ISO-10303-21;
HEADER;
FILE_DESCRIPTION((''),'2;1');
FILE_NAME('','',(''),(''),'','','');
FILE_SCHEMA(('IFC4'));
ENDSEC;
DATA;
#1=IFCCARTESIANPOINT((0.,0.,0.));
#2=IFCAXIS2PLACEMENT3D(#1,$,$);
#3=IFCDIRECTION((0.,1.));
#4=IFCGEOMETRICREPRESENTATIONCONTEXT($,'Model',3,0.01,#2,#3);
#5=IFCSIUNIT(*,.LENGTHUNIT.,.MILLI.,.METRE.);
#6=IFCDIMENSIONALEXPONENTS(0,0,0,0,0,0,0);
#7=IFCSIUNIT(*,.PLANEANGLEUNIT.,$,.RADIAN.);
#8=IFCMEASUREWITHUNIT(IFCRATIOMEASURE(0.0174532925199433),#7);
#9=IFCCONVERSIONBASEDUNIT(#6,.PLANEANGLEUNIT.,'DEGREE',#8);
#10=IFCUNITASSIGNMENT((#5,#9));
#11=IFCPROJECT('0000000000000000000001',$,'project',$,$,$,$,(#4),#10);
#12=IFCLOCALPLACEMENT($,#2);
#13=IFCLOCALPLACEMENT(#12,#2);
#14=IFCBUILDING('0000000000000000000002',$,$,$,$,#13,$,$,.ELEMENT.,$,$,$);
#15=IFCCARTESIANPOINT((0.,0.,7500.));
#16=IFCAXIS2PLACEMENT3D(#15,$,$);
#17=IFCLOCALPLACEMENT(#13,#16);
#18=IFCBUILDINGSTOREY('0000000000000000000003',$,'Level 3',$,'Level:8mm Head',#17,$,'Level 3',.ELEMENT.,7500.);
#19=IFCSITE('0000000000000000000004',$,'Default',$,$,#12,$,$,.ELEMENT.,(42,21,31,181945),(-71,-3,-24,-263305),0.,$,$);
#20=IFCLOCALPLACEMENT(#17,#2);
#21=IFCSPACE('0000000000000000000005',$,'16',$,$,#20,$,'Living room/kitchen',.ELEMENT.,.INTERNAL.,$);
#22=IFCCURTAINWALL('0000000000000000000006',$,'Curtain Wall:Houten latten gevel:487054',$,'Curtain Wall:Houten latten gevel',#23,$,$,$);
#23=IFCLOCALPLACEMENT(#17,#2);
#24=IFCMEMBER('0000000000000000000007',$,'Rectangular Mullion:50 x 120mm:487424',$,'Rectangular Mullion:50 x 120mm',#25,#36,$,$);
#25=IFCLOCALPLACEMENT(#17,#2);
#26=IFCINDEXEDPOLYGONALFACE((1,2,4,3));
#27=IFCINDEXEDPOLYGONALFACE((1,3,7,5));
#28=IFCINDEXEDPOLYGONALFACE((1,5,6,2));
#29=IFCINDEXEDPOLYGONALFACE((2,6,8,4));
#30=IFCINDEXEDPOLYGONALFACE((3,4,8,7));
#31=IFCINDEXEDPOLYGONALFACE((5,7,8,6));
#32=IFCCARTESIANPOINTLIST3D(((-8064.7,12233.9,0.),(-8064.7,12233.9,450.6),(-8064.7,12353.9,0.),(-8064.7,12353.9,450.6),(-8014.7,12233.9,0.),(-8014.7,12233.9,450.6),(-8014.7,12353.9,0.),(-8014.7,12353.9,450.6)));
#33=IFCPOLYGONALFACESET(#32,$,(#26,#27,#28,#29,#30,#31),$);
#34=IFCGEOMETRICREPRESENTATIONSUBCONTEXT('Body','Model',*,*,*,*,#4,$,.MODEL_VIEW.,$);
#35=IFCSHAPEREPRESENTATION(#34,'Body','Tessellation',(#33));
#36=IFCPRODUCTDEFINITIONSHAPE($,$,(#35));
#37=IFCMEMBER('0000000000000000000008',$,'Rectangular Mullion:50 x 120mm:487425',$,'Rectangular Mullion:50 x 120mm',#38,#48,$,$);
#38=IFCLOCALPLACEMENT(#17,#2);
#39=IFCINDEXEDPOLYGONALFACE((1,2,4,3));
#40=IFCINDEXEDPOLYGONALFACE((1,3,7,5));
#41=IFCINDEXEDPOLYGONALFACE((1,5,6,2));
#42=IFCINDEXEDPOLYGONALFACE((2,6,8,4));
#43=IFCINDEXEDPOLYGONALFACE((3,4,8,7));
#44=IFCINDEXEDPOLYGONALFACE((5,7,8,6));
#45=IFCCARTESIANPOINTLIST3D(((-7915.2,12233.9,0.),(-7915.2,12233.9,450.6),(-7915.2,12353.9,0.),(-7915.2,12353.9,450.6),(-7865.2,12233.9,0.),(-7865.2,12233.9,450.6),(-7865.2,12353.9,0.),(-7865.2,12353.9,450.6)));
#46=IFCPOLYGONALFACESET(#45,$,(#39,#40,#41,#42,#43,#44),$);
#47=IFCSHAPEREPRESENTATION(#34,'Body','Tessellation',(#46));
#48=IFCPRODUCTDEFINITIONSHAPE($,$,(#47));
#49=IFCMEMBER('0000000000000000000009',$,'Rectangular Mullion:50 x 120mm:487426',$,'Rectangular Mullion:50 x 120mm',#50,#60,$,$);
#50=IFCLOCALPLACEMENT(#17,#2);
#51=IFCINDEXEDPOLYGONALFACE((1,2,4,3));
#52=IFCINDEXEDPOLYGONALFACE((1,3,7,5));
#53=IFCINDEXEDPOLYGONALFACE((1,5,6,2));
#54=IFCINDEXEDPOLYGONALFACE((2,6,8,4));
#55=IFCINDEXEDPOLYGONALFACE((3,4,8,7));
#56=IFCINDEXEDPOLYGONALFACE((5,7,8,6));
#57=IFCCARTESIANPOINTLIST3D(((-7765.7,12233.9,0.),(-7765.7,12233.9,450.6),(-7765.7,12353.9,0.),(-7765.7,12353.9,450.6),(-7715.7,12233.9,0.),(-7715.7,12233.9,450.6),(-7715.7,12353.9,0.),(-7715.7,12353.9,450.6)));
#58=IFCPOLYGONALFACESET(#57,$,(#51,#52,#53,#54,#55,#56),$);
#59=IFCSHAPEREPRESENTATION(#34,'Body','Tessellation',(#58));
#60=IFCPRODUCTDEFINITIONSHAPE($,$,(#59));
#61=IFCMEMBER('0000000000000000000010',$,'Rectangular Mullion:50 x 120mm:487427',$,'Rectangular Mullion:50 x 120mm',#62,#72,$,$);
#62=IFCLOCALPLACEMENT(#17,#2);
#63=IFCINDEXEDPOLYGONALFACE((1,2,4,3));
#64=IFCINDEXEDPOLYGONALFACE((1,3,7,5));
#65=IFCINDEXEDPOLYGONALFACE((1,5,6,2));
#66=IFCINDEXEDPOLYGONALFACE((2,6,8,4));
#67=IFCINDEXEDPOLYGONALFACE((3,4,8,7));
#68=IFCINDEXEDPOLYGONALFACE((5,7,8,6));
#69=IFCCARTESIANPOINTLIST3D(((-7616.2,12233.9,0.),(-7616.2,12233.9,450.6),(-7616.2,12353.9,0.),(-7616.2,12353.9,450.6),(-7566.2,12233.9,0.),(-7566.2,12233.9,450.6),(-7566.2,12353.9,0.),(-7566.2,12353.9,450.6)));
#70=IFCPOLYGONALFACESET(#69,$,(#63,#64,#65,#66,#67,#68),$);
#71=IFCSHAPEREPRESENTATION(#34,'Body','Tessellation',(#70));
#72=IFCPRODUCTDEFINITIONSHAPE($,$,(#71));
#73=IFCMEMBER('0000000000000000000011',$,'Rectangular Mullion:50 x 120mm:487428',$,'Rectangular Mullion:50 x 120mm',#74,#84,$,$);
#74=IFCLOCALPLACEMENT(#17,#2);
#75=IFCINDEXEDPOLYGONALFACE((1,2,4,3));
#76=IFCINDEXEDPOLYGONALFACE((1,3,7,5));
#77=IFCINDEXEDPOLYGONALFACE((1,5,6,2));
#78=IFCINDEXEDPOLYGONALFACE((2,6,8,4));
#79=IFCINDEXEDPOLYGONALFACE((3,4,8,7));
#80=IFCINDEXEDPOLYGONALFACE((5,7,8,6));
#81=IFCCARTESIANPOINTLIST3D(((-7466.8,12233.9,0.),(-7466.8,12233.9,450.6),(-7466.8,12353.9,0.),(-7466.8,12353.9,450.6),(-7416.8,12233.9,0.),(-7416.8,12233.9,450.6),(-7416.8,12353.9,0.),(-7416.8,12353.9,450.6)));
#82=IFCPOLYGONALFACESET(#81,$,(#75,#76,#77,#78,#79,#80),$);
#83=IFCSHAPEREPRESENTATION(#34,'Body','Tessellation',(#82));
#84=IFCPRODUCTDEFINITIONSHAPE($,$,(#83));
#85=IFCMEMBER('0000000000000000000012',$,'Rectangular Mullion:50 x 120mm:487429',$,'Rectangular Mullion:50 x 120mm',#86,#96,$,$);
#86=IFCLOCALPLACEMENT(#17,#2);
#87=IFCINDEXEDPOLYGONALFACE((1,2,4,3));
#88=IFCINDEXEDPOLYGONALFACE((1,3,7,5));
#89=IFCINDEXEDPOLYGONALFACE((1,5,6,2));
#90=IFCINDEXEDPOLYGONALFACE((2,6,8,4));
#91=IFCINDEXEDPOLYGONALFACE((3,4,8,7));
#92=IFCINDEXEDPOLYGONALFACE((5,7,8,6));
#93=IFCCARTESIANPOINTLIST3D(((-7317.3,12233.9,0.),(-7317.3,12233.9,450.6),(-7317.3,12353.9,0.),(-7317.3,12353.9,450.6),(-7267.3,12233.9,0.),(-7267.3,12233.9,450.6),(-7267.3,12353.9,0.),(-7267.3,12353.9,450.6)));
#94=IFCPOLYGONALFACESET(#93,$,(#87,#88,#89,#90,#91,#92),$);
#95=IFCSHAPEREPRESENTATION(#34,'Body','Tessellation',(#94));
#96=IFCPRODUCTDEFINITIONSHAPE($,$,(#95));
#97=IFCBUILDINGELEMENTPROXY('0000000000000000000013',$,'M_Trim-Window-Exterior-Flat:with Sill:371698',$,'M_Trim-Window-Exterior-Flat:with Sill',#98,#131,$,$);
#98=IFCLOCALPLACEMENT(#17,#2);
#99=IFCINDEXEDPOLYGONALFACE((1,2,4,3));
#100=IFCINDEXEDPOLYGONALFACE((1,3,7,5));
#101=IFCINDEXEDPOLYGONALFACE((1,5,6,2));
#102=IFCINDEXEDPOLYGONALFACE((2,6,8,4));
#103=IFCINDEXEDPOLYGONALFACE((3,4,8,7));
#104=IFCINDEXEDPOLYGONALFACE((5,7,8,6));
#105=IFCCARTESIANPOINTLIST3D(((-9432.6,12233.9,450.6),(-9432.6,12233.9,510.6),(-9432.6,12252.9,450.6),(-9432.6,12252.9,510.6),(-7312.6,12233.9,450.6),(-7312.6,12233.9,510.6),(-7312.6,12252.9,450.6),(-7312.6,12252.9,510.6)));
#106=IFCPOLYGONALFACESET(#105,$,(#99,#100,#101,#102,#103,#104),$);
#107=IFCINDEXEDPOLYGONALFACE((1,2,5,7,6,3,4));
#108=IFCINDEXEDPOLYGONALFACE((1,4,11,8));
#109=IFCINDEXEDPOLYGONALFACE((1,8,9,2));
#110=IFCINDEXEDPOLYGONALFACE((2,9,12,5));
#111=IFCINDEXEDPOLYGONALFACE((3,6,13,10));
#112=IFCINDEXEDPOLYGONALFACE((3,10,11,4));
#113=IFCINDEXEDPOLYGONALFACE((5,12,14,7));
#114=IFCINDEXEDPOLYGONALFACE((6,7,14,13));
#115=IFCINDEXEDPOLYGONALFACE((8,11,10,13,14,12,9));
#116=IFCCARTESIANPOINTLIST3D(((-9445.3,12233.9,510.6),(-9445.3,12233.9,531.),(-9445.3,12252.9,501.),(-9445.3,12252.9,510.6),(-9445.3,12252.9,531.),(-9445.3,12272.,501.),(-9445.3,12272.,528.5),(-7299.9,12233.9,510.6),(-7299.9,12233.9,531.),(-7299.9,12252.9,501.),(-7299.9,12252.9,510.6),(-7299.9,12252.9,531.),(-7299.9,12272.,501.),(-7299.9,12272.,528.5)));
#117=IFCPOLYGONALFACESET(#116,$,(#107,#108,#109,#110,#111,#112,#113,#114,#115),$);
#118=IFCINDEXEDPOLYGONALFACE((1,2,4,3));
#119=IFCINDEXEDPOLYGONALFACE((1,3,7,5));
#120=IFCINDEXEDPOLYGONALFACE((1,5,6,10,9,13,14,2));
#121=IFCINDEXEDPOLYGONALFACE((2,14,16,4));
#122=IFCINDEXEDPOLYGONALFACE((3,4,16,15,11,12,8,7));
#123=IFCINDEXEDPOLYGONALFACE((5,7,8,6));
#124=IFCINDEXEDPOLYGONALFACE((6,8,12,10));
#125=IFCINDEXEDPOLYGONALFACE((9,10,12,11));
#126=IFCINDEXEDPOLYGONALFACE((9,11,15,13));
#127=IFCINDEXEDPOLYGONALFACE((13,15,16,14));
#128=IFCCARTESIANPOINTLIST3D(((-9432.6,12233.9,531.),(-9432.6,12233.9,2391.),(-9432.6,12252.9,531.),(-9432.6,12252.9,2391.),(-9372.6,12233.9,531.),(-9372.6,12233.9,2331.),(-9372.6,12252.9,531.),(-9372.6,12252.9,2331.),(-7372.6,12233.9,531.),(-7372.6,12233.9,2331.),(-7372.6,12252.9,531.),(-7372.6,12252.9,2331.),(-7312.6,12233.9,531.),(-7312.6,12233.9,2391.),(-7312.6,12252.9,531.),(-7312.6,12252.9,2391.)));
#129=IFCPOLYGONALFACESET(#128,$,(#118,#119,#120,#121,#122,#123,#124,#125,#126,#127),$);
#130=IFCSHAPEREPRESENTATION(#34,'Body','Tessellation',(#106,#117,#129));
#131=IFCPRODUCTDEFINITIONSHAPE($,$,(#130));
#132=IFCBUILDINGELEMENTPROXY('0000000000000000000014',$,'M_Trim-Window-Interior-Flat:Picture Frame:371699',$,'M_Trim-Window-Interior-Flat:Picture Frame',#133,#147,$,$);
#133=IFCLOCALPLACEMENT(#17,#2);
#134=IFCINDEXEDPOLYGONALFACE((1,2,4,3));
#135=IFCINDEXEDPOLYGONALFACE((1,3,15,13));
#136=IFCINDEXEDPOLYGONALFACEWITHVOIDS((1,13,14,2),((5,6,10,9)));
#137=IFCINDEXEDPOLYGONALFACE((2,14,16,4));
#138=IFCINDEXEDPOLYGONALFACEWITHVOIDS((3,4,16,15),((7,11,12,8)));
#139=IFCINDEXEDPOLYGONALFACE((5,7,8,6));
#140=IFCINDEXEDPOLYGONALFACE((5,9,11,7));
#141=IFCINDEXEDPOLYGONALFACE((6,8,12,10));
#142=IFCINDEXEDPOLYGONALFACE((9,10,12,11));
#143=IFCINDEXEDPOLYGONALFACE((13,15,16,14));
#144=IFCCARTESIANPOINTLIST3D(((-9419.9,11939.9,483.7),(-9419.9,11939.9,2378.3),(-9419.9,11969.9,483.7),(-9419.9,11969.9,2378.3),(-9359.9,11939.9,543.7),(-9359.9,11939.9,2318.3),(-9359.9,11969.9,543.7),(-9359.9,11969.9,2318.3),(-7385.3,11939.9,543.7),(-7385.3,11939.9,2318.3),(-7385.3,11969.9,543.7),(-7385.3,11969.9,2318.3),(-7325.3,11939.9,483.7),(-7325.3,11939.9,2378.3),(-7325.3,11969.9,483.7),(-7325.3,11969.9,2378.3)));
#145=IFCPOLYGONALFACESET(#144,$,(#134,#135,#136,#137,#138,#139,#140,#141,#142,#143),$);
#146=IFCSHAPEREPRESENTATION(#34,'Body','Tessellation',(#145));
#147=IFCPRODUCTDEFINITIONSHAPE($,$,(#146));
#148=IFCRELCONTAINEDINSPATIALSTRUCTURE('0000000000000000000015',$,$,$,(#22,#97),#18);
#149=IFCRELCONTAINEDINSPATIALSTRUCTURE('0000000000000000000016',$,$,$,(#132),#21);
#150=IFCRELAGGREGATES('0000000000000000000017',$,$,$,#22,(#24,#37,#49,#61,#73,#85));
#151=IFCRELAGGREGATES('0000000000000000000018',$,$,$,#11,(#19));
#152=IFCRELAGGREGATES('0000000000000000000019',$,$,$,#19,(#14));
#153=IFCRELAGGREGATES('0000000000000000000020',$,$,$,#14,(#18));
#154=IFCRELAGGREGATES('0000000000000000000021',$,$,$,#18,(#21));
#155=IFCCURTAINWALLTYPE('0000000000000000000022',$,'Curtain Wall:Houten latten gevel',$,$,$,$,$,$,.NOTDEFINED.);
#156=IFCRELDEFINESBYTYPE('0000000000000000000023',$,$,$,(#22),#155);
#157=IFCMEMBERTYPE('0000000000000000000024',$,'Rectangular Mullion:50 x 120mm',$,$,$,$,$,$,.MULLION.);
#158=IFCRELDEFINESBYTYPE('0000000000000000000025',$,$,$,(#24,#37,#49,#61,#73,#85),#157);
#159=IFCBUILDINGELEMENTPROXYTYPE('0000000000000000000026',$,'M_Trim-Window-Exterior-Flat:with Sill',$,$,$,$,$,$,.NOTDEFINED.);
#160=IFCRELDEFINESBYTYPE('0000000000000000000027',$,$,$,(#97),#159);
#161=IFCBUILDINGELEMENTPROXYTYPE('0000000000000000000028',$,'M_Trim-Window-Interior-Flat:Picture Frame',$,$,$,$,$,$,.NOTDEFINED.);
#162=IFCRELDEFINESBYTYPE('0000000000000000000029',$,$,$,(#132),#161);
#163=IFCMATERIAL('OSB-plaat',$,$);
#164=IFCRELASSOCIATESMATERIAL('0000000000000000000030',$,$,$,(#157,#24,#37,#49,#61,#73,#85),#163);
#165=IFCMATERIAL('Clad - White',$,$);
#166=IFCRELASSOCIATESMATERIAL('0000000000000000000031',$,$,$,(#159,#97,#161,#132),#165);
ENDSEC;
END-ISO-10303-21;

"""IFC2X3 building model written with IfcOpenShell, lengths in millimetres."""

from ifc_helpers import new_model, entity, si_unit, converted_unit, direction, frame, frame_2d, origin, origin_2d_with_axis, place, context, subcontext, project, spatial, polyline, rectangle, outline, extrude, source, transform, mapped, material, type_object, type_shapes, element, aggregate, save


model = new_model("IFC2X3")

# Units and contexts
model_context = context("Model", 3, precision=0.01, world=origin(), true_north=direction((0.0, 1.0)))
body_context = subcontext(model_context, "Body", "Model", "MODEL_VIEW")
ifc_project = project(units=[si_unit("LENGTHUNIT", "METRE", prefix="MILLI"), converted_unit("PLANEANGLEUNIT", "DEGREE", entity("IfcRatioMeasure", 0.0174532925199433), si_unit("PLANEANGLEUNIT", "RADIAN"), dimensions=[0, 0, 0, 0, 0, 0, 0])], contexts=[model_context])

# Site, building, storey
site_placement = place(None, frame((0.0, 0.0, 0.0)))
site = spatial("IfcSite", under=ifc_project, at=site_placement, Name="Default", CompositionType="ELEMENT", RefLatitude=(42, 21, 31, 181945), RefLongitude=(-71, -3, -24, -263305), RefElevation=0.0)
building_placement = place(site_placement, origin())
building = spatial("IfcBuilding", under=site, at=building_placement, CompositionType="ELEMENT")
storey_placement = place(building_placement, frame((0.0, 0.0, 7500.0)))
storey = spatial("IfcBuildingStorey", under=building, at=storey_placement, Name="Level 3", ObjectType="Level:8mm Head", LongName="Level 3", CompositionType="ELEMENT", Elevation=7500.0)

# Curtain wall, members
curtain_wall_type = type_object("IfcCurtainWallType", Name="Curtain Wall:Houten latten gevel", PredefinedType="NOTDEFINED")
curtain_wall_placement = place(storey_placement, frame((0.0, 0.0, -7500.0)))
curtain_wall = element("IfcCurtainWall", 1, at=curtain_wall_placement, inside=storey, type_object=curtain_wall_type, Name="Curtain Wall:Houten latten gevel:487054", ObjectType="Curtain Wall:Houten latten gevel")
ifc_material_1 = material(Name="OSB-plaat")
member_type_1 = type_object("IfcMemberType", Name="Rectangular Mullion:50 x 120mm", PredefinedType="MULLION", material=ifc_material_1)
shared_shape_1 = source(origin(), body_context, "Body", "SweptSolid", [
    extrude(rectangle(XDim=120.0, YDim=50.0, at=origin_2d_with_axis()), frame((0.0, 0.0, -450.6), z_axis=(0.0, 0.0, 1.0), x_axis=(0.0, -1.0, 0.0)), (0.0, 0.0, 1.0), 450.6),
])
type_shapes(member_type_1, [shared_shape_1])
member_1_placement = place(storey_placement, frame((-8039.7, 12293.9, 0.0), z_axis=(0.0, 0.0, -1.0), x_axis=(1.0, 0.0, 0.0)))
member_1 = element("IfcMember", 2, at=member_1_placement, type_object=member_type_1, material=ifc_material_1, Name="Rectangular Mullion:50 x 120mm:487424", ObjectType="Rectangular Mullion:50 x 120mm", context=body_context, shape_type="MappedRepresentation", body=[
    mapped(shared_shape_1, transform((0.0, 0.0, 0.0), scale=1.0)),
])
member_2_placement = place(storey_placement, frame((-7890.2, 12293.9, 0.0), z_axis=(0.0, 0.0, -1.0), x_axis=(1.0, 0.0, 0.0)))
member_2 = element("IfcMember", 3, at=member_2_placement, type_object=member_type_1, material=ifc_material_1, Name="Rectangular Mullion:50 x 120mm:487425", ObjectType="Rectangular Mullion:50 x 120mm", context=body_context, shape_type="MappedRepresentation", body=[
    mapped(shared_shape_1, transform((0.0, 0.0, 0.0), scale=1.0)),
])
member_3_placement = place(storey_placement, frame((-7740.7, 12293.9, 0.0), z_axis=(0.0, 0.0, -1.0), x_axis=(1.0, 0.0, 0.0)))
member_3 = element("IfcMember", 4, at=member_3_placement, type_object=member_type_1, material=ifc_material_1, Name="Rectangular Mullion:50 x 120mm:487426", ObjectType="Rectangular Mullion:50 x 120mm", context=body_context, shape_type="MappedRepresentation", body=[
    mapped(shared_shape_1, transform((0.0, 0.0, 0.0), scale=1.0)),
])
member_4_placement = place(storey_placement, frame((-7591.2, 12293.9, 0.0), z_axis=(0.0, 0.0, -1.0), x_axis=(1.0, 0.0, 0.0)))
member_4 = element("IfcMember", 5, at=member_4_placement, type_object=member_type_1, material=ifc_material_1, Name="Rectangular Mullion:50 x 120mm:487427", ObjectType="Rectangular Mullion:50 x 120mm", context=body_context, shape_type="MappedRepresentation", body=[
    mapped(shared_shape_1, transform((0.0, 0.0, 0.0), scale=1.0)),
])
member_5_placement = place(storey_placement, frame((-7441.8, 12293.9, 0.0), z_axis=(0.0, 0.0, -1.0), x_axis=(1.0, 0.0, 0.0)))
member_5 = element("IfcMember", 6, at=member_5_placement, type_object=member_type_1, material=ifc_material_1, Name="Rectangular Mullion:50 x 120mm:487428", ObjectType="Rectangular Mullion:50 x 120mm", context=body_context, shape_type="MappedRepresentation", body=[
    mapped(shared_shape_1, transform((0.0, 0.0, 0.0), scale=1.0)),
])
member_6_placement = place(storey_placement, frame((-7292.3, 12293.9, 0.0), z_axis=(0.0, 0.0, -1.0), x_axis=(1.0, 0.0, 0.0)))
member_6 = element("IfcMember", 7, at=member_6_placement, type_object=member_type_1, material=ifc_material_1, Name="Rectangular Mullion:50 x 120mm:487429", ObjectType="Rectangular Mullion:50 x 120mm", context=body_context, shape_type="MappedRepresentation", body=[
    mapped(shared_shape_1, transform((0.0, 0.0, 0.0), scale=1.0)),
])
aggregate(curtain_wall, [member_1, member_2, member_3, member_4, member_5, member_6])

# Shared definitions
ifc_material_2 = material(Name="Clad - White")

# Building element proxy
building_element_proxy_type_1 = type_object("IfcBuildingElementProxyType", Name="M_Trim-Window-Exterior-Flat:with Sill", PredefinedType="NOTDEFINED", material=ifc_material_2)
shared_shape_2 = source(origin(), body_context, "Body", "SweptSolid", [
    extrude(rectangle(XDim=2120.0, YDim=60.0, at=frame_2d((0.0, 0.0), x_axis=(1.0, 0.0))), frame((0.0, -1850.4, 0.0), z_axis=(0.0, 0.0, 1.0), x_axis=(-1.0, 0.0, 0.0)), (0.0, 0.0, 1.0), 19.1),
    extrude(outline(polyline([(-19.0, -15.2), (0.0, -15.2), (0.0, -5.7), (19.0, -5.7), (19.0, 14.8), (0.0, 14.8), (-19.0, 12.3), (-19.0, -15.2)])), frame((-1072.7, -1814.8, 19.0), z_axis=(1.0, 0.0, 0.0), x_axis=(0.0, 0.0, -1.0)), (0.0, 0.0, 1.0), 2145.4),
    extrude(outline(polyline([(-945.0, -1060.0), (915.0, -1060.0), (915.0, -1000.0), (-885.0, -1000.0), (-885.0, 1000.0), (915.0, 1000.0), (915.0, 1060.0), (-945.0, 1060.0), (-945.0, -1060.0)])), frame((0.0, -885.0, 0.0), z_axis=(0.0, 0.0, 1.0), x_axis=(0.0, -1.0, 0.0)), (0.0, 0.0, 1.0), 19.1),
])
type_shapes(building_element_proxy_type_1, [shared_shape_2])
proxy_1_placement = place(storey_placement, frame((-8372.6, 12233.9, 2331.0), z_axis=(0.0, 1.0, 0.0), x_axis=(-1.0, 0.0, 0.0)))
element("IfcBuildingElementProxy", 8, at=proxy_1_placement, inside=storey, type_object=building_element_proxy_type_1, material=ifc_material_2, Name="M_Trim-Window-Exterior-Flat:with Sill:371698", ObjectType="M_Trim-Window-Exterior-Flat:with Sill", context=body_context, shape_type="MappedRepresentation", body=[
    mapped(shared_shape_2, transform((0.0, 0.0, 0.0), scale=1.0)),
])

# Shared definitions
space_placement = place(storey_placement, origin())
space = spatial("IfcSpace", under=storey, at=space_placement, Name="16", LongName="Living room/kitchen", CompositionType="ELEMENT", InteriorOrExteriorSpace="INTERNAL")

# Building element proxy
building_element_proxy_type_2 = type_object("IfcBuildingElementProxyType", Name="M_Trim-Window-Interior-Flat:Picture Frame", PredefinedType="NOTDEFINED", material=ifc_material_2)
shared_shape_3 = source(origin(), body_context, "Body", "SweptSolid", [
    extrude(outline(polyline([(-1047.3, -947.3), (1047.3, -947.3), (1047.3, 947.3), (-1047.3, 947.3), (-1047.3, -947.3)]), holes=[polyline([(-987.3, -887.3), (-987.3, 887.3), (987.3, 887.3), (987.3, -887.3), (-987.3, -887.3)])]), frame((0.0, -900.0, 0.0), z_axis=(0.0, 0.0, 1.0), x_axis=(-1.0, 0.0, 0.0)), (0.0, 0.0, 1.0), 30.0),
])
type_shapes(building_element_proxy_type_2, [shared_shape_3])
proxy_2_placement = place(space_placement, frame((-8372.6, 11969.9, 2331.0), z_axis=(0.0, -1.0, 0.0), x_axis=(1.0, 0.0, 0.0)))
element("IfcBuildingElementProxy", 9, at=proxy_2_placement, inside=space, type_object=building_element_proxy_type_2, material=ifc_material_2, Name="M_Trim-Window-Interior-Flat:Picture Frame:371699", ObjectType="M_Trim-Window-Interior-Flat:Picture Frame", context=body_context, shape_type="MappedRepresentation", body=[
    mapped(shared_shape_3, transform((0.0, 0.0, 0.0), scale=1.0)),
])

save(model, "model.ifc")
